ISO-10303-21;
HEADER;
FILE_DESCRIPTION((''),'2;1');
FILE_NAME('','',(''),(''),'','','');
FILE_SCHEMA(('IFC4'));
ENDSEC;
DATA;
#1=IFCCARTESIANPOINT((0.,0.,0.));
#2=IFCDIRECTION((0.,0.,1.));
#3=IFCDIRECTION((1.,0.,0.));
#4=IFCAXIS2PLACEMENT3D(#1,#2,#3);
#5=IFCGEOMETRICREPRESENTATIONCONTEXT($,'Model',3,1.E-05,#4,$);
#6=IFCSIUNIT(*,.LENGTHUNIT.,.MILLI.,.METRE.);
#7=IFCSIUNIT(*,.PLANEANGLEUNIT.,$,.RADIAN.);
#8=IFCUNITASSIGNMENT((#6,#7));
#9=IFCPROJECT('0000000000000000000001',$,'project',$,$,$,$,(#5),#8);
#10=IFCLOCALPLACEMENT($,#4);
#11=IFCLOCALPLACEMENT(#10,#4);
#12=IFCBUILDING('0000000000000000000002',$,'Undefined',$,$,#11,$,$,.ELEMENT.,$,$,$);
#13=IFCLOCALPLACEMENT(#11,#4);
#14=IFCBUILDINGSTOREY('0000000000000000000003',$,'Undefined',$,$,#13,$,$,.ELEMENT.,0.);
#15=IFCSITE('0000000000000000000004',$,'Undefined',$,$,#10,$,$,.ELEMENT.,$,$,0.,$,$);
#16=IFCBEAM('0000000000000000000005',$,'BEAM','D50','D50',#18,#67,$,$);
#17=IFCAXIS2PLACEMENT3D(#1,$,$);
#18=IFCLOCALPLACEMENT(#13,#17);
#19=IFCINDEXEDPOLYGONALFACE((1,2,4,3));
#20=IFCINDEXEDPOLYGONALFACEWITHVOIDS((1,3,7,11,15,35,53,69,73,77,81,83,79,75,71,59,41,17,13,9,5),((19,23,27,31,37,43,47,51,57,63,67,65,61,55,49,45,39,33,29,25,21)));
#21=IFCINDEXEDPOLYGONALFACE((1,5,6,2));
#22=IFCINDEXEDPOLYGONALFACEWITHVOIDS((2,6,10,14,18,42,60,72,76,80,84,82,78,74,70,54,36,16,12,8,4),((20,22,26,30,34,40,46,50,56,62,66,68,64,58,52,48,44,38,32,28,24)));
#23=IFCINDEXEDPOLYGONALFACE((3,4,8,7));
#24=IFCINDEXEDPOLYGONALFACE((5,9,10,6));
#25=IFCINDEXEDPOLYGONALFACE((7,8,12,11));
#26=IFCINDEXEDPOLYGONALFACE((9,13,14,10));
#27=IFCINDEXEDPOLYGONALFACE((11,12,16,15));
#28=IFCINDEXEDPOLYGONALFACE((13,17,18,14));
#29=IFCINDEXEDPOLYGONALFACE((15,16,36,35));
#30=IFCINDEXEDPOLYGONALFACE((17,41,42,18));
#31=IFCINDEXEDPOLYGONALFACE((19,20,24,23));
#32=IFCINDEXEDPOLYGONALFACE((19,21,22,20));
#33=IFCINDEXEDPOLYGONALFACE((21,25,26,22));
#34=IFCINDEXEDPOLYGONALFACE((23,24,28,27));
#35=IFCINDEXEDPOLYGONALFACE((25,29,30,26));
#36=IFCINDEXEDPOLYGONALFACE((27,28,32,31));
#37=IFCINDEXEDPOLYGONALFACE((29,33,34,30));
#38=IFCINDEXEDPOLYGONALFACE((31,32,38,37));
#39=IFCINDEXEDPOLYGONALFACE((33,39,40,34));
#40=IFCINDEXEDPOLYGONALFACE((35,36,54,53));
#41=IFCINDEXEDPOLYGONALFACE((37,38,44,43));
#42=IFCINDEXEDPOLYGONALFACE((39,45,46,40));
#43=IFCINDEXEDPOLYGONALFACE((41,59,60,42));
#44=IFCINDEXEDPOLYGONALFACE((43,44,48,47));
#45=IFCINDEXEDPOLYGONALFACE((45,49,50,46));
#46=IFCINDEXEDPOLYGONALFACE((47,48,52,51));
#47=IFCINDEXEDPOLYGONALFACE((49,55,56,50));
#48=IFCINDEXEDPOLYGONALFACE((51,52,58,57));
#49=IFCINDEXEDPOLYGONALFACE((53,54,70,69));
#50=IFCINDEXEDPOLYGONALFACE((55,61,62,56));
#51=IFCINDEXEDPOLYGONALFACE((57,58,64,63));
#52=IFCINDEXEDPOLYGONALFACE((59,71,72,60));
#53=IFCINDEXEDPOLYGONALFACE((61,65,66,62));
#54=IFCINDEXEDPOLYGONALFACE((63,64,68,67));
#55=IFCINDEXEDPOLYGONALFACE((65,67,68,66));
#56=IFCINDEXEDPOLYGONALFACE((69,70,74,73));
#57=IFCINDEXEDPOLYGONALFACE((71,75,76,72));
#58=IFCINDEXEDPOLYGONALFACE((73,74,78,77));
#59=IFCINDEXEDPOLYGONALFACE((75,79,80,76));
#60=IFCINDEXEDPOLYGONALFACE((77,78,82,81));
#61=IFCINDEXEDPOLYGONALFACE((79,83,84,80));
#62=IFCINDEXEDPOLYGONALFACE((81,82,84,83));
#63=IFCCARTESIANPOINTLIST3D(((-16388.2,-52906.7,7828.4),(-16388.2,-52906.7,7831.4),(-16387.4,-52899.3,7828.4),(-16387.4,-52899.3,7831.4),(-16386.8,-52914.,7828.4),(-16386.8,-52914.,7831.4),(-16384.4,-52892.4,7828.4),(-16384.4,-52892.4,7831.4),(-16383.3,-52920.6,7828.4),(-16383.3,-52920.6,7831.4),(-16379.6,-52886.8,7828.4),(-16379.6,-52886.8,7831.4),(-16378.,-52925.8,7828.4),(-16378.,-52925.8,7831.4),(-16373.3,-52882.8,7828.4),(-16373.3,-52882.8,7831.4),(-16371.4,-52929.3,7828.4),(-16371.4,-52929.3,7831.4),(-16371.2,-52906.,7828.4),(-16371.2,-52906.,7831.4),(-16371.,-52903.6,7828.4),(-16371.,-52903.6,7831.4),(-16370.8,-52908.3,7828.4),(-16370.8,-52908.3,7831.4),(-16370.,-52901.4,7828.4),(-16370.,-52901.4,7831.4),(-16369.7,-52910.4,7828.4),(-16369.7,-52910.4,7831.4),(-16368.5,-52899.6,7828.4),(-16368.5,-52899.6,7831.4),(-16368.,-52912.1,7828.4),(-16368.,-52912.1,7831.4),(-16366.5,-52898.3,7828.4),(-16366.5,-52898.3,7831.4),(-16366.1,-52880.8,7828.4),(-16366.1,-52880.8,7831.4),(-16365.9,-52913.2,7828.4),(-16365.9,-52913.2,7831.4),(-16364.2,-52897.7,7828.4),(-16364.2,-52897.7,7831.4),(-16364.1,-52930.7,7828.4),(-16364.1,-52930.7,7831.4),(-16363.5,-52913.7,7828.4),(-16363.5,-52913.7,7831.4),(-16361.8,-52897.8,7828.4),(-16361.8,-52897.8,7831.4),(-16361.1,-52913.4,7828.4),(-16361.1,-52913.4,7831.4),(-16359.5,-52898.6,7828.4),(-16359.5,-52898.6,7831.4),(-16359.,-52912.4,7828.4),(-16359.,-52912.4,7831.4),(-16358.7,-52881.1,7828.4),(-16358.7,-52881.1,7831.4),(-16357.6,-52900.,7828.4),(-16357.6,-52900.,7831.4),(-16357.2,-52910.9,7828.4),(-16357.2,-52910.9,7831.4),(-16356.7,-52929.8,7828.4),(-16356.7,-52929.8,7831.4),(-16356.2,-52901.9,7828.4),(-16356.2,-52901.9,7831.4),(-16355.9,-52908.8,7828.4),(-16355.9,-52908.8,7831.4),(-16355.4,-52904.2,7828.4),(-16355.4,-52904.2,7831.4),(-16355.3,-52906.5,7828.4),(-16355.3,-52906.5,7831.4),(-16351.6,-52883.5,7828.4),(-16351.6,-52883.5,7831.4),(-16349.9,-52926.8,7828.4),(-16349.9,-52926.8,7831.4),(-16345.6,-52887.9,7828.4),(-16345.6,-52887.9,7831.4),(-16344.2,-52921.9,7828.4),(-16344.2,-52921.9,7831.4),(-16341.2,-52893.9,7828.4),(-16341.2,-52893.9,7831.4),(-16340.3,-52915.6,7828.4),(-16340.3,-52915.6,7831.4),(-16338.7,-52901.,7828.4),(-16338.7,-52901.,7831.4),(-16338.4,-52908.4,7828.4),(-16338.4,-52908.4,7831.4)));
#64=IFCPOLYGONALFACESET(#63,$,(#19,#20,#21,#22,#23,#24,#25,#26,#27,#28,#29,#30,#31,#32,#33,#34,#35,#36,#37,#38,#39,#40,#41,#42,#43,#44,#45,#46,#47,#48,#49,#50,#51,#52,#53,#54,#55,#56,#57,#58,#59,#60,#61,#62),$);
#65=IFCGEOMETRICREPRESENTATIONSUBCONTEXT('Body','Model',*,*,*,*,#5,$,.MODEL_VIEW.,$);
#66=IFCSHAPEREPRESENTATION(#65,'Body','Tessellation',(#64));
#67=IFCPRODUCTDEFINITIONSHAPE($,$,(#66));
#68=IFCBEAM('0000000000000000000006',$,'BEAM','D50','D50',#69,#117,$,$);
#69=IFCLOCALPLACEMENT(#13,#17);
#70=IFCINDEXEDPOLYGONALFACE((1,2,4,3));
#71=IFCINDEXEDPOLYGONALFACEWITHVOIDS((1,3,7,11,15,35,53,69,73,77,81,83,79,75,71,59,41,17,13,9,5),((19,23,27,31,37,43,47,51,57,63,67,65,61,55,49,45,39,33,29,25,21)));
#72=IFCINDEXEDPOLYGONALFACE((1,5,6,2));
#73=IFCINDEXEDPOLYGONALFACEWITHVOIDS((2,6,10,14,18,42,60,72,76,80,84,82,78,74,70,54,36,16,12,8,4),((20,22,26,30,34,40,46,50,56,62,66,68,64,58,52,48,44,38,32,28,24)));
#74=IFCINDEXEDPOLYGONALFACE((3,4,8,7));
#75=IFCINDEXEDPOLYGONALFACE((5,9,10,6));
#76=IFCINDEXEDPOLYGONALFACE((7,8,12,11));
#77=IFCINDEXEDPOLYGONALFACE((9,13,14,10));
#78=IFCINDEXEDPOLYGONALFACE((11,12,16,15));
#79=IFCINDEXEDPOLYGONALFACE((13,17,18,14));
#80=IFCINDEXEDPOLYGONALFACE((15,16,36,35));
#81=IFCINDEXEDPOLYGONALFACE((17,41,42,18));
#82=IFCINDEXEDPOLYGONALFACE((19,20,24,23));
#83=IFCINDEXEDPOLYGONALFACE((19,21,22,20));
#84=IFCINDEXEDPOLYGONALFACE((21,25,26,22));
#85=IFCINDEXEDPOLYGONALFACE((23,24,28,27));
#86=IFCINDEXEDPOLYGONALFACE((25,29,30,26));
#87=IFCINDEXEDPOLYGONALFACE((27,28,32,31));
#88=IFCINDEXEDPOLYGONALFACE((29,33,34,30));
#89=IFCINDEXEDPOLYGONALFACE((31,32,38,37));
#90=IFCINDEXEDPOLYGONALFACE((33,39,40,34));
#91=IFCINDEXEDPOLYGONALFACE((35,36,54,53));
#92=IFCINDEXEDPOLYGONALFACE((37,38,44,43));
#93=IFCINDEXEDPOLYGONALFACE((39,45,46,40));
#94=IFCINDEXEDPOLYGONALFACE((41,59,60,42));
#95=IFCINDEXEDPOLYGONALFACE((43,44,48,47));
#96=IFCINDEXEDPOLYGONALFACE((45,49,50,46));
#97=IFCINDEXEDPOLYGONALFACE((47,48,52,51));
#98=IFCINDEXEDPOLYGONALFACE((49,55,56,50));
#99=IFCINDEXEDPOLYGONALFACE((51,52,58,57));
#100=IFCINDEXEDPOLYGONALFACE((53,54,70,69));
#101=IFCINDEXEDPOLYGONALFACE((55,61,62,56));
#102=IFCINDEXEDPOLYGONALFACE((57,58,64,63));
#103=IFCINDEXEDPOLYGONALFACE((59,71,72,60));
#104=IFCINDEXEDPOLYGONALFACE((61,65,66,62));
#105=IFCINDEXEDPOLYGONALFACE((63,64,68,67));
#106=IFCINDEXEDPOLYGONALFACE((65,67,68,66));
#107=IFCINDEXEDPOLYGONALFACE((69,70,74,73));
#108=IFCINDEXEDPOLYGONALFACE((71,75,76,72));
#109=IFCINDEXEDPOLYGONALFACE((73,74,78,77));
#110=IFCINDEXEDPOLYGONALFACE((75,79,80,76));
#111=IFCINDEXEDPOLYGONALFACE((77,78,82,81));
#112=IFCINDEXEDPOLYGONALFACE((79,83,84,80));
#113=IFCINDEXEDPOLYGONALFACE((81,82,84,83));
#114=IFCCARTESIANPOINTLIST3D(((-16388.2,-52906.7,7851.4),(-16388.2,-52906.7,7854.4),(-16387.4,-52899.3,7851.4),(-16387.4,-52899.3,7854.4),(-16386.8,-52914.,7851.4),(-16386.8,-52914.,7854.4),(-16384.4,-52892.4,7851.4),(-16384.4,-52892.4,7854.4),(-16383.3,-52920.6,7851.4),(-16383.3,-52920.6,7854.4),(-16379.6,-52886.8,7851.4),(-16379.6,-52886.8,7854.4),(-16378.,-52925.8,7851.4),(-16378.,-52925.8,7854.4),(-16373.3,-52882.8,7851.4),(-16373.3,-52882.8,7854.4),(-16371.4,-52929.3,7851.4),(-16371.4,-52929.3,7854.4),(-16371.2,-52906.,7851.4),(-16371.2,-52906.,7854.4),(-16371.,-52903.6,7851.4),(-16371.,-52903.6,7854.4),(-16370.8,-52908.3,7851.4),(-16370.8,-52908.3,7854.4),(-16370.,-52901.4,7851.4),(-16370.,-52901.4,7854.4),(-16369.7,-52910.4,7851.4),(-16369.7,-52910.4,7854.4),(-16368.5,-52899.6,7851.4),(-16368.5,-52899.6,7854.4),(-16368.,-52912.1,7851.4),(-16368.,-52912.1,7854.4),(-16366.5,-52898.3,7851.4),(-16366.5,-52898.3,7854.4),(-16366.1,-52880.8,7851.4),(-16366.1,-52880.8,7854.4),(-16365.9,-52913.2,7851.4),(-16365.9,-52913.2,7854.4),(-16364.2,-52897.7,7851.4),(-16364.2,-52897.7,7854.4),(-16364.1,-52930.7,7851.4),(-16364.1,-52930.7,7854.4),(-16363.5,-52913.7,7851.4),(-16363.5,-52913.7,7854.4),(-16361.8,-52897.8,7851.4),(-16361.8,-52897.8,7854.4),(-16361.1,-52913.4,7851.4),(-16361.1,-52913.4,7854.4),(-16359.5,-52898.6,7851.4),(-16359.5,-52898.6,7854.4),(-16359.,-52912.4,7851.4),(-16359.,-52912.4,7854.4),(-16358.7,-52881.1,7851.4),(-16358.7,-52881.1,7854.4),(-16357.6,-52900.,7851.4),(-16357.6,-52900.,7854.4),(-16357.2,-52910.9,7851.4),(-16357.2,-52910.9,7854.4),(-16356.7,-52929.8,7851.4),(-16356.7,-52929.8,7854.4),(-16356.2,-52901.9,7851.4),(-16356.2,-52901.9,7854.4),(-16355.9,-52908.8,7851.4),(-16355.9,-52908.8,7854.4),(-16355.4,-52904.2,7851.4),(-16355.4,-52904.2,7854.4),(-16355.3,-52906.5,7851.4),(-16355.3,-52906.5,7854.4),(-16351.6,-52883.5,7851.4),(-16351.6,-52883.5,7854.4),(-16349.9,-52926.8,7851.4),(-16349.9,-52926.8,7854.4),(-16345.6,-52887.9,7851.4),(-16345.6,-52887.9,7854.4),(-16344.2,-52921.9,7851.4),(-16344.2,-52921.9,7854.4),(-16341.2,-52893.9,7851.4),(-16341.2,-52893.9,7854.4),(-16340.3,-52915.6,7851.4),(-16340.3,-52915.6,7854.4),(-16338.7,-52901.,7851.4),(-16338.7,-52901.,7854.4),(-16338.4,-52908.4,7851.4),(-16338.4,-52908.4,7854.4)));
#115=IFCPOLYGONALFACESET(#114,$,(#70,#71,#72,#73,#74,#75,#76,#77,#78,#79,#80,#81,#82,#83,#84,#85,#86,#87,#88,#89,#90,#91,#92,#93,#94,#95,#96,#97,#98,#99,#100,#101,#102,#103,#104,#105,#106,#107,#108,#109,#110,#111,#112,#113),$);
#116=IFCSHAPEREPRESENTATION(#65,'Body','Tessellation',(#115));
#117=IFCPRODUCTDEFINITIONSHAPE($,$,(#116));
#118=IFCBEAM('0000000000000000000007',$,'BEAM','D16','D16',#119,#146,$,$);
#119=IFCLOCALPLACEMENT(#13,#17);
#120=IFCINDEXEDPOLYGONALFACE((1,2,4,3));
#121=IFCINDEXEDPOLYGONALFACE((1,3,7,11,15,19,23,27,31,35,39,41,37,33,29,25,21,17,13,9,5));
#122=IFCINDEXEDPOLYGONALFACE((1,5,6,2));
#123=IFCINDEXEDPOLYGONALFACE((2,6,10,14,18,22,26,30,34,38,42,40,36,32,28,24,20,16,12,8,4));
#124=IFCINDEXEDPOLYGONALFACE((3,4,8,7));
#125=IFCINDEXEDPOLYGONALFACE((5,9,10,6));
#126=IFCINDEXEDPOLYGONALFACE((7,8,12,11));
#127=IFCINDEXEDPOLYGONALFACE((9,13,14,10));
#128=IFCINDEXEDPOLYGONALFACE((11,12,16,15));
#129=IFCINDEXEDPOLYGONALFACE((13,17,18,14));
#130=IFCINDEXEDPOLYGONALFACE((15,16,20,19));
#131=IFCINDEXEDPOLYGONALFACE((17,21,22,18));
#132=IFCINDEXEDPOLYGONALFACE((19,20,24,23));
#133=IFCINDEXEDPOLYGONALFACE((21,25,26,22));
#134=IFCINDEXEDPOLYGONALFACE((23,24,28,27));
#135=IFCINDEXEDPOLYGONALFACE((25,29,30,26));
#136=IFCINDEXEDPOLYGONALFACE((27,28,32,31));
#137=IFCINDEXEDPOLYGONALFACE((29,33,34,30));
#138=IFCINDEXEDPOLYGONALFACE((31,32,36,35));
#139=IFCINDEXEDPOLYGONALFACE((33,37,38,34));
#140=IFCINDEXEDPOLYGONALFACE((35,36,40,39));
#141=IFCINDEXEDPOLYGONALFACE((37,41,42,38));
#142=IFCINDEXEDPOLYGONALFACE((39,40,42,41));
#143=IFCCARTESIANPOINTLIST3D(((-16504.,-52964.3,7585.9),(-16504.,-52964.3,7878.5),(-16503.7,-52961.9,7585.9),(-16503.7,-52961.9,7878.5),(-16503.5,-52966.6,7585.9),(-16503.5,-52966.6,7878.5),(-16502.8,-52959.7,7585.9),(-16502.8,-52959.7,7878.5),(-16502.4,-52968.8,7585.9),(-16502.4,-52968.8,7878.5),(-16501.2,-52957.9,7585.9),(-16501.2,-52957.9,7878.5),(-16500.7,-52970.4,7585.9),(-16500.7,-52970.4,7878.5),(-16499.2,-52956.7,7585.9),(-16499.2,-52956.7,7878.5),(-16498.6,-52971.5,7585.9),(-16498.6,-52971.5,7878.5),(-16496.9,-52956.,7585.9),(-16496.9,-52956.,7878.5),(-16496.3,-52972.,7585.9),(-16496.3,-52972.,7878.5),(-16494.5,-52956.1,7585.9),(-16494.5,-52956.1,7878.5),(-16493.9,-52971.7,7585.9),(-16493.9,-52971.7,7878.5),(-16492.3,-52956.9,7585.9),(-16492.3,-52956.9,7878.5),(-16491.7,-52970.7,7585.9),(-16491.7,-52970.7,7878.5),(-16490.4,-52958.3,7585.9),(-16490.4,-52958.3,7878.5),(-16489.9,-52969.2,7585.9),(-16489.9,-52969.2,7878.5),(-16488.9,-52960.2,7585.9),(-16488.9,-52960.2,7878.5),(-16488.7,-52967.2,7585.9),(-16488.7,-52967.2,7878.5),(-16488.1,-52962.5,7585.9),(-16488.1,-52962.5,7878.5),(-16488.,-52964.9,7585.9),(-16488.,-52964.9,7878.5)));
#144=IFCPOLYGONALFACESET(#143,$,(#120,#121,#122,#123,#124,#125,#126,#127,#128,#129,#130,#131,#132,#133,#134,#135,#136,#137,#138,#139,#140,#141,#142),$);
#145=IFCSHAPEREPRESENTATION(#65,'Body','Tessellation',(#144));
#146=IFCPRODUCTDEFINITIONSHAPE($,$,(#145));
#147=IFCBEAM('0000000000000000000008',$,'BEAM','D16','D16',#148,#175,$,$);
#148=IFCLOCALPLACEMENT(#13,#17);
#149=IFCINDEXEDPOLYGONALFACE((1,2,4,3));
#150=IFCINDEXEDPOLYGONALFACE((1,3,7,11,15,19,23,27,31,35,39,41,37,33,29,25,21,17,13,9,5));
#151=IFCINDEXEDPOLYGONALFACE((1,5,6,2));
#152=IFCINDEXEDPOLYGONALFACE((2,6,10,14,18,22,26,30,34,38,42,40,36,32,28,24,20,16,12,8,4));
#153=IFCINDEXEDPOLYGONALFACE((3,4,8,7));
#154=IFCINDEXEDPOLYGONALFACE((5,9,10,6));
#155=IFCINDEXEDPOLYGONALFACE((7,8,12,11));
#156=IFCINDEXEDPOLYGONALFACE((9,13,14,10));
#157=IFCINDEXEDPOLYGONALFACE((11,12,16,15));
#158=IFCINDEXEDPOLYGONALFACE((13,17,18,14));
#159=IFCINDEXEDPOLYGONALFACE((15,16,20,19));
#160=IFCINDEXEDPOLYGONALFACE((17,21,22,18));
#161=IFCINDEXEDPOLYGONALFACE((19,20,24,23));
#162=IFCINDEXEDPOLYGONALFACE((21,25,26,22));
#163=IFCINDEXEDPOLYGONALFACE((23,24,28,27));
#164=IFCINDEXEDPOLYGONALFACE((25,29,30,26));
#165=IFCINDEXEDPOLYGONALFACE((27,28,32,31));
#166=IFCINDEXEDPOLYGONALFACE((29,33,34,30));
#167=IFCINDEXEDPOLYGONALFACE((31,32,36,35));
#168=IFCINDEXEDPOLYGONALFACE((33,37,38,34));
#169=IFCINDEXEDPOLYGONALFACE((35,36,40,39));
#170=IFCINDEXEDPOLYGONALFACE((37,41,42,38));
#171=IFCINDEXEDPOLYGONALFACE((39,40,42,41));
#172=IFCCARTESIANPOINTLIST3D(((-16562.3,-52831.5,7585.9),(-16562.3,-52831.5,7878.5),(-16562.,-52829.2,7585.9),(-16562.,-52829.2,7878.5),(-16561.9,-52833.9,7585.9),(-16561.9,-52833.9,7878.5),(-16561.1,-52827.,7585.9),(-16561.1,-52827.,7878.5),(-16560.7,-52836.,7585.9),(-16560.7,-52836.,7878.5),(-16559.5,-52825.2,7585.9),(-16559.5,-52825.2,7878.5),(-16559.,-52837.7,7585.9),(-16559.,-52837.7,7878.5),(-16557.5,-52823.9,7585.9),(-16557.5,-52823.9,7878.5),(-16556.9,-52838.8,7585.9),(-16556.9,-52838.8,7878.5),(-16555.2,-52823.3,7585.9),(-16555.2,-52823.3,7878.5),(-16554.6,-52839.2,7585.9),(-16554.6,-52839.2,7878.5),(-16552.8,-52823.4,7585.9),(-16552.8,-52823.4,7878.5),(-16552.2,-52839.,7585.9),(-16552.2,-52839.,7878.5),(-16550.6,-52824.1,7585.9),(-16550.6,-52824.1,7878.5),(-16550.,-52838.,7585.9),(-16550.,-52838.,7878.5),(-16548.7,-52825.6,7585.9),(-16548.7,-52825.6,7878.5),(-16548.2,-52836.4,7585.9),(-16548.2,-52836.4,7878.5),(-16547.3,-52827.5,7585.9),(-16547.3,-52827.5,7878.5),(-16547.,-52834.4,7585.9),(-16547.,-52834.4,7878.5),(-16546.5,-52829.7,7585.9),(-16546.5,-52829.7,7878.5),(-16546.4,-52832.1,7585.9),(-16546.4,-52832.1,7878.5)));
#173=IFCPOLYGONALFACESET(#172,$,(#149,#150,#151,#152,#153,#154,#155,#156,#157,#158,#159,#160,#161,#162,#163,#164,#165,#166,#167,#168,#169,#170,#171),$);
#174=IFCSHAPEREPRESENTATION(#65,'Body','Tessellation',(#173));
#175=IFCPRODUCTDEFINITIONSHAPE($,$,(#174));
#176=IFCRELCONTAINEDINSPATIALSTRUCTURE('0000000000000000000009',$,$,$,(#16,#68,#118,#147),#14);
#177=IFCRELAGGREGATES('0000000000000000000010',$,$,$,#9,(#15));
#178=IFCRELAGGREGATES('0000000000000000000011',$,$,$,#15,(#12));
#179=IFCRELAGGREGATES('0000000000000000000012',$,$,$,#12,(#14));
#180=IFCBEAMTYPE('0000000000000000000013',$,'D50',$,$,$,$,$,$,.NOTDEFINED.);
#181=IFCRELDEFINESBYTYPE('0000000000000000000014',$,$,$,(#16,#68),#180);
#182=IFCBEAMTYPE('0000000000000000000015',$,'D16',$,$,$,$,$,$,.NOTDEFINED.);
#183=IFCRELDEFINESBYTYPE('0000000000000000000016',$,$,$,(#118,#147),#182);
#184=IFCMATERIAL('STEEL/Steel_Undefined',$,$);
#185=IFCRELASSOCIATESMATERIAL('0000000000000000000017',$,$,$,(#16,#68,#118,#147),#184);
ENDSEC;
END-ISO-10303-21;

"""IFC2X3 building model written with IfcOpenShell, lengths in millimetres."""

from ifc_helpers import new_model, si_unit, frame, origin_with_axes, origin_2d_with_axis, place, context, subcontext, project, spatial, circle, extrude, material, type_object, element, save


model = new_model("IFC2X3")

# Units and contexts
model_context = context("Model", 3, precision=1e-05, world=origin_with_axes())
body_context = subcontext(model_context, "Body", "Model", "MODEL_VIEW")
ifc_project = project(units=[si_unit("LENGTHUNIT", "METRE", prefix="MILLI"), si_unit("PLANEANGLEUNIT", "RADIAN")], contexts=[model_context])

# Site, building, storey
site_placement = place(None, origin_with_axes())
site = spatial("IfcSite", under=ifc_project, at=site_placement, Name="Undefined", CompositionType="ELEMENT", RefElevation=0.0)
building_placement = place(site_placement, origin_with_axes())
building = spatial("IfcBuilding", under=site, at=building_placement, Name="Undefined", CompositionType="ELEMENT")
storey_placement = place(building_placement, origin_with_axes())
storey = spatial("IfcBuildingStorey", under=building, at=storey_placement, Name="Undefined", CompositionType="ELEMENT", Elevation=0.0)

# Shared definitions
ifc_material_1 = material(Name="STEEL/Steel_Undefined")

# Beams, openings
beam_type_1 = type_object("IfcBeamType", Name="D50", PredefinedType="NOTDEFINED")
beam_1_placement = place(storey_placement, frame((-16363.2, -52905.7, 7831.4), z_axis=(-0.915553, -0.402197, 0.0), x_axis=(0.0, 0.0, -1.0)))
beam_1 = element("IfcBeam", 1, at=beam_1_placement, inside=storey, type_object=beam_type_1, material=ifc_material_1, Name="BEAM", Description="D50", ObjectType="D50", context=body_context, shape_type="SweptSolid", body=[
    extrude(circle(Radius=25.0, at=origin_2d_with_axis()), frame((3.0, 0.0, 0.0), z_axis=(-1.0, 0.0, 0.0), x_axis=(0.0, -1.0, 0.0)), (0.0, 0.0, 1.0), 3.0),
])
opening_1_placement = place(storey_placement, frame((-16363.2, -52905.7, 7831.4), z_axis=(-0.915553, -0.402197, 0.0), x_axis=(0.0, 0.0, -1.0)))
element("IfcOpeningElement", 2, at=opening_1_placement, cuts=beam_1, ObjectType="Recess", context=body_context, shape_type="SweptSolid", body=[
    extrude(circle(Radius=8.0, at=origin_2d_with_axis()), frame((245.5, 0.0, 0.0), z_axis=(-1.0, 0.0, 0.0), x_axis=(0.0, -1.0, 0.0)), (0.0, 0.0, 1.0), 292.6),
])
beam_2_placement = place(storey_placement, frame((-16363.2, -52905.7, 7854.4), z_axis=(-0.915553, -0.402197, 0.0), x_axis=(0.0, 0.0, -1.0)))
beam_2 = element("IfcBeam", 3, at=beam_2_placement, inside=storey, type_object=beam_type_1, material=ifc_material_1, Name="BEAM", Description="D50", ObjectType="D50", context=body_context, shape_type="SweptSolid", body=[
    extrude(circle(Radius=25.0, at=origin_2d_with_axis()), frame((3.0, 0.0, 0.0), z_axis=(-1.0, 0.0, 0.0), x_axis=(0.0, -1.0, 0.0)), (0.0, 0.0, 1.0), 3.0),
])
opening_2_placement = place(storey_placement, frame((-16363.2, -52905.7, 7854.4), z_axis=(-0.915553, -0.402197, 0.0), x_axis=(0.0, 0.0, -1.0)))
element("IfcOpeningElement", 4, at=opening_2_placement, cuts=beam_2, ObjectType="Recess", context=body_context, shape_type="SweptSolid", body=[
    extrude(circle(Radius=8.0, at=origin_2d_with_axis()), frame((268.5, 0.0, 0.0), z_axis=(-1.0, 0.0, 0.0), x_axis=(0.0, -1.0, 0.0)), (0.0, 0.0, 1.0), 292.6),
])

# Beams
beam_type_2 = type_object("IfcBeamType", Name="D16", PredefinedType="NOTDEFINED")
for number, where, z_axis, x_axis, name in (
    (5, (-16496.0, -52964.0, 7878.5), (-0.915553, -0.402197, 0.0), (0.0, 0.0, -1.0), "BEAM"),
    (6, (-16554.3, -52831.2, 7878.5), (-0.915553, -0.402197, 0.0), (0.0, 0.0, -1.0), "BEAM"),
):
    element("IfcBeam", number, at=place(storey_placement, frame(where, z_axis=z_axis, x_axis=x_axis)), inside=storey, type_object=beam_type_2, material=ifc_material_1, Name=name, Description="D16", ObjectType="D16", context=body_context, shape_type="SweptSolid", body=[
        extrude(circle(Radius=8.0, at=origin_2d_with_axis()), frame((292.6, 0.0, 0.0), z_axis=(-1.0, 0.0, 0.0), x_axis=(0.0, -1.0, 0.0)), (0.0, 0.0, 1.0), 292.6),
    ])

save(model, "model.ifc")
